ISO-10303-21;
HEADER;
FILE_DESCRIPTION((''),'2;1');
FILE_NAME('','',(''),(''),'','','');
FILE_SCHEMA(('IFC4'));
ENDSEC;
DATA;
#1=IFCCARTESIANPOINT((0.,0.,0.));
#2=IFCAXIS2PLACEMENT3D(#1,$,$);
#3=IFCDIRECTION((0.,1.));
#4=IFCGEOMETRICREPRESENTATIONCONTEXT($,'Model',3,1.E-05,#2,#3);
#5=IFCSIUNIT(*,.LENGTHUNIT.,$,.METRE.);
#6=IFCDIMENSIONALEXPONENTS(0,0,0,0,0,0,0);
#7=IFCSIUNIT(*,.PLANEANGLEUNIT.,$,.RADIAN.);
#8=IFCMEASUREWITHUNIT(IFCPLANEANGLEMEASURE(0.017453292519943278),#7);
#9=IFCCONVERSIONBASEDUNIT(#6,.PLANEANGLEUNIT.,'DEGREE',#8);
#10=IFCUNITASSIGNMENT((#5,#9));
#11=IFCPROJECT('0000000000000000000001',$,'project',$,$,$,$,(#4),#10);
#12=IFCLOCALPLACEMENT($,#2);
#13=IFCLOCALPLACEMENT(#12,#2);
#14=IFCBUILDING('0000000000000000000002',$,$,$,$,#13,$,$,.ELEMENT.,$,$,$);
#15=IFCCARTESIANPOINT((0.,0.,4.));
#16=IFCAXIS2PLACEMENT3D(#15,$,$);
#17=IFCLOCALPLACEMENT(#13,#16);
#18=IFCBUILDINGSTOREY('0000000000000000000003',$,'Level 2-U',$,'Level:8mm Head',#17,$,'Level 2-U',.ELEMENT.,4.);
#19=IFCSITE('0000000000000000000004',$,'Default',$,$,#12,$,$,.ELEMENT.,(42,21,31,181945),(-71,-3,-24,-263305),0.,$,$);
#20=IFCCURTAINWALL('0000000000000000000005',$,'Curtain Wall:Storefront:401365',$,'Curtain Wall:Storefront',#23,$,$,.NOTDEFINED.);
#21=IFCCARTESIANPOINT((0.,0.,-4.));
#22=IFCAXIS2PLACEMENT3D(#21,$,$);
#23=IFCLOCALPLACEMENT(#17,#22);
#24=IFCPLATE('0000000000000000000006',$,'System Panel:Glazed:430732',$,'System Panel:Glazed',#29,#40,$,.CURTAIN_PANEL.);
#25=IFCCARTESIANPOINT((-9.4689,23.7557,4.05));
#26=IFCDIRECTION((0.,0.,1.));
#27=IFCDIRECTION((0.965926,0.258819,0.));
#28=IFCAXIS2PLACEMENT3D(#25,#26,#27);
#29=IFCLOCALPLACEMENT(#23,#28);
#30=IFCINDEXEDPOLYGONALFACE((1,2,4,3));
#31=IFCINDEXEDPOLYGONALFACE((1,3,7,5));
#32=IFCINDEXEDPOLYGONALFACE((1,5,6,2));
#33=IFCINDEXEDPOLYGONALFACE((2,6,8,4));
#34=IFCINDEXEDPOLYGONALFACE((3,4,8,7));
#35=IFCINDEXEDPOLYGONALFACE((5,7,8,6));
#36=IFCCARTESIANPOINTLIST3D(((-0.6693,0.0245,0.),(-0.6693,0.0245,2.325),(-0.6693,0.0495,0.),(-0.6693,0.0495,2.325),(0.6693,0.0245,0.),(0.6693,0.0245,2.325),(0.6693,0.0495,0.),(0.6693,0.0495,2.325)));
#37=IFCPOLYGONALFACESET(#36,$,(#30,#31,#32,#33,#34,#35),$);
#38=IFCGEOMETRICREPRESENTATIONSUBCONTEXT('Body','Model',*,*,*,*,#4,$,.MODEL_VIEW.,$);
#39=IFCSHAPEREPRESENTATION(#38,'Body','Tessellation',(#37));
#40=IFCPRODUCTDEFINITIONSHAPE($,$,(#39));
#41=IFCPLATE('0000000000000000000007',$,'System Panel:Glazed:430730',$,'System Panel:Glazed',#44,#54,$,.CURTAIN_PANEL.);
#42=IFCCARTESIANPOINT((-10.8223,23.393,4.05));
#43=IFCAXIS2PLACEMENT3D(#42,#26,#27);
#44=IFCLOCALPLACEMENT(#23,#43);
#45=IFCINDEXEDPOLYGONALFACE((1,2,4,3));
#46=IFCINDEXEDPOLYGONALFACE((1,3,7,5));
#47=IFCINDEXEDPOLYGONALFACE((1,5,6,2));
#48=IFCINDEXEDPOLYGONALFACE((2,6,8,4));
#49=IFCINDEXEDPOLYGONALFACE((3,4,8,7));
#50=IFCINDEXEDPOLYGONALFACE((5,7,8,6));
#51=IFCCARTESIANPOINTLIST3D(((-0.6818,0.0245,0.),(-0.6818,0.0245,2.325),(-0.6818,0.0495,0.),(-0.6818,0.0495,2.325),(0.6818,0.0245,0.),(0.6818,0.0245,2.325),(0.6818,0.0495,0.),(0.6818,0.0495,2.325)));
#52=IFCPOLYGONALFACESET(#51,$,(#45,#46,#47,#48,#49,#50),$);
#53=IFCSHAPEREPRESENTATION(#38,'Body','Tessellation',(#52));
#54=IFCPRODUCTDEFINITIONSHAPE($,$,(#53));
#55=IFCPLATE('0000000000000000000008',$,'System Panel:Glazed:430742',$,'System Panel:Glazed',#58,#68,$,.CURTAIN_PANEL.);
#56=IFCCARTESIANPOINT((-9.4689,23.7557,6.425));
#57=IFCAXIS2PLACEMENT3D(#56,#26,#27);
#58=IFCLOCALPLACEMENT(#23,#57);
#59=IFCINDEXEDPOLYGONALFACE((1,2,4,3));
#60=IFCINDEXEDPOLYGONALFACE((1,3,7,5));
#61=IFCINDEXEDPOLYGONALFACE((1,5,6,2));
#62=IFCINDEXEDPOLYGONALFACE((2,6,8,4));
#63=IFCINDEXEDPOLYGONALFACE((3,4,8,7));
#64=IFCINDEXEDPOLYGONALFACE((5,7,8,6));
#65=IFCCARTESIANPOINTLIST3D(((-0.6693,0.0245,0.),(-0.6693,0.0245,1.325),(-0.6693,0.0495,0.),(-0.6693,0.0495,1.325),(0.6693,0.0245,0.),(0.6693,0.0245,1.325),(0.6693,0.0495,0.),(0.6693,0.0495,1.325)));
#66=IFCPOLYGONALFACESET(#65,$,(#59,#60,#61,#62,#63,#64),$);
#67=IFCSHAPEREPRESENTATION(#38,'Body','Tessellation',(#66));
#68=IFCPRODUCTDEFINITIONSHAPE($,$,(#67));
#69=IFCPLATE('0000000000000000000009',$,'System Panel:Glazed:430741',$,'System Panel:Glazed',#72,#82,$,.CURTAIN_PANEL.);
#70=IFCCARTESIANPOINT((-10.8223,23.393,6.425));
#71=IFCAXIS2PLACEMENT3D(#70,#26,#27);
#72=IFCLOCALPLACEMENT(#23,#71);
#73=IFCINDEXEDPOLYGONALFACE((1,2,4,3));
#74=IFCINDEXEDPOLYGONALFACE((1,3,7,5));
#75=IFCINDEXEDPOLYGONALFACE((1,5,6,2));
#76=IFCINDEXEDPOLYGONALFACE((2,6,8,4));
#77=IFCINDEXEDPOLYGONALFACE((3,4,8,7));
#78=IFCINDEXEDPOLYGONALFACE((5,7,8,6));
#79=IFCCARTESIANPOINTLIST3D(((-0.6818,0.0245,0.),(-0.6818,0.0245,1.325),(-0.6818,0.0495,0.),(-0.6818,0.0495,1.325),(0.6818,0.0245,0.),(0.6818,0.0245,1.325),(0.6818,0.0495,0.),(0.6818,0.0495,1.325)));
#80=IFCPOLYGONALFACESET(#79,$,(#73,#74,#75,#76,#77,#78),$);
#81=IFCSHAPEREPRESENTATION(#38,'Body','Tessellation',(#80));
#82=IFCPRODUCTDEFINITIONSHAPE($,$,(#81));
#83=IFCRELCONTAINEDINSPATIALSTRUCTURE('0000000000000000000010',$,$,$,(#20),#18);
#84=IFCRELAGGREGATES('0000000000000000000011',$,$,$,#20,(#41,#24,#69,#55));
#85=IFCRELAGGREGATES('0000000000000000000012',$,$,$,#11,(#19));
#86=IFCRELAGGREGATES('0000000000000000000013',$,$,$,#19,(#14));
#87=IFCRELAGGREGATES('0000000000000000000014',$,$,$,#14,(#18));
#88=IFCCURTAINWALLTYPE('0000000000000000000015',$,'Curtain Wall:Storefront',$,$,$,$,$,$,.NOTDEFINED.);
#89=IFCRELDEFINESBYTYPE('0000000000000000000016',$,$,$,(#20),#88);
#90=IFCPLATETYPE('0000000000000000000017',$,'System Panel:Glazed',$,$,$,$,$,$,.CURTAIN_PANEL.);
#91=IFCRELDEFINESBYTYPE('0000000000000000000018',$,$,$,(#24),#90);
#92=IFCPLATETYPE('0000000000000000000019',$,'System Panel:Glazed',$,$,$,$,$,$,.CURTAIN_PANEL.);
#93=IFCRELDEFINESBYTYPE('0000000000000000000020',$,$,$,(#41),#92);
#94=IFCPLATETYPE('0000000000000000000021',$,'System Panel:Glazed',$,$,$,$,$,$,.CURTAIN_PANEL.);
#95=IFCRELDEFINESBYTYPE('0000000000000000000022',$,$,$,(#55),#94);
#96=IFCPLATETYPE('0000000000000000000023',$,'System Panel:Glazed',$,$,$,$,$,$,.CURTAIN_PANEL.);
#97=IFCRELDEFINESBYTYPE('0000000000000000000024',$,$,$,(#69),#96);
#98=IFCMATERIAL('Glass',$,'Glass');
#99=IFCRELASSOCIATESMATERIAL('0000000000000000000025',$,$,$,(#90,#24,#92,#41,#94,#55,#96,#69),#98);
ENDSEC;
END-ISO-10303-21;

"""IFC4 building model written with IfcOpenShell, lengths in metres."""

from ifc_helpers import new_model, entity, si_unit, converted_unit, direction, frame, origin, place, context, subcontext, project, spatial, indexed_curve, outline, extrude, source, transform, mapped, material, type_object, type_shapes, element, aggregate, save


model = new_model("IFC4")

# Units and contexts
model_context = context("Model", 3, precision=1e-05, world=origin(), true_north=direction((0.0, 1.0)))
body_context = subcontext(model_context, "Body", "Model", "MODEL_VIEW")
ifc_project = project(units=[si_unit("LENGTHUNIT", "METRE"), converted_unit("PLANEANGLEUNIT", "DEGREE", entity("IfcPlaneAngleMeasure", 0.017453292519943278), si_unit("PLANEANGLEUNIT", "RADIAN"), dimensions=[0, 0, 0, 0, 0, 0, 0])], contexts=[model_context])

# Site, building, storey
site_placement = place(None, origin())
site = spatial("IfcSite", under=ifc_project, at=site_placement, Name="Default", CompositionType="ELEMENT", RefLatitude=(42, 21, 31, 181945), RefLongitude=(-71, -3, -24, -263305), RefElevation=0.0)
building_placement = place(site_placement, origin())
building = spatial("IfcBuilding", under=site, at=building_placement, CompositionType="ELEMENT")
storey_placement = place(building_placement, frame((0.0, 0.0, 4.0)))
storey = spatial("IfcBuildingStorey", under=building, at=storey_placement, Name="Level 2-U", ObjectType="Level:8mm Head", LongName="Level 2-U", CompositionType="ELEMENT", Elevation=4.0)

# Curtain wall, plates
curtain_wall_type = type_object("IfcCurtainWallType", Name="Curtain Wall:Storefront", PredefinedType="NOTDEFINED")
curtain_wall_placement = place(storey_placement, frame((0.0, 0.0, -4.0)))
curtain_wall = element("IfcCurtainWall", 1, at=curtain_wall_placement, inside=storey, type_object=curtain_wall_type, Name="Curtain Wall:Storefront:401365", ObjectType="Curtain Wall:Storefront", PredefinedType="NOTDEFINED")
ifc_material_1 = material(Name="Glass", Category="Glass")
plate_type_1 = type_object("IfcPlateType", Name="System Panel:Glazed", PredefinedType="CURTAIN_PANEL", material=ifc_material_1)
shared_shape_1 = source(origin(), body_context, "Body", "SweptSolid", [
    extrude(outline(indexed_curve([(-0.0125, -0.6693), (0.0125, -0.6693), (0.0125, 0.6693), (-0.0125, 0.6693), (-0.0125, -0.6693)], self_intersect=False)), frame((0.0, 0.037, 0.0), z_axis=(0.0, 0.0, 1.0), x_axis=(0.0, 1.0, 0.0)), (0.0, 0.0, 1.0), 2.325),
])
type_shapes(plate_type_1, [shared_shape_1])
plate_1_placement = place(curtain_wall_placement, frame((-9.4689, 23.7557, 4.05), z_axis=(0.0, 0.0, 1.0), x_axis=(0.965926, 0.258819, 0.0)))
plate_1 = element("IfcPlate", 2, at=plate_1_placement, type_object=plate_type_1, material=ifc_material_1, Name="System Panel:Glazed:430732", ObjectType="System Panel:Glazed", PredefinedType="CURTAIN_PANEL", context=body_context, shape_type="MappedRepresentation", body=[
    mapped(shared_shape_1, transform((0.0, 0.0, 0.0), scale=1.0)),
])
plate_type_2 = type_object("IfcPlateType", Name="System Panel:Glazed", PredefinedType="CURTAIN_PANEL", material=ifc_material_1)
shared_shape_2 = source(origin(), body_context, "Body", "SweptSolid", [
    extrude(outline(indexed_curve([(-0.0125, -0.6818), (0.0125, -0.6818), (0.0125, 0.6818), (-0.0125, 0.6818), (-0.0125, -0.6818)], self_intersect=False)), frame((0.0, 0.037, 0.0), z_axis=(0.0, 0.0, 1.0), x_axis=(0.0, 1.0, 0.0)), (0.0, 0.0, 1.0), 2.325),
])
type_shapes(plate_type_2, [shared_shape_2])
plate_2_placement = place(curtain_wall_placement, frame((-10.8223, 23.393, 4.05), z_axis=(0.0, 0.0, 1.0), x_axis=(0.965926, 0.258819, 0.0)))
plate_2 = element("IfcPlate", 3, at=plate_2_placement, type_object=plate_type_2, material=ifc_material_1, Name="System Panel:Glazed:430730", ObjectType="System Panel:Glazed", PredefinedType="CURTAIN_PANEL", context=body_context, shape_type="MappedRepresentation", body=[
    mapped(shared_shape_2, transform((0.0, 0.0, 0.0), scale=1.0)),
])
plate_type_3 = type_object("IfcPlateType", Name="System Panel:Glazed", PredefinedType="CURTAIN_PANEL", material=ifc_material_1)
shared_shape_3 = source(origin(), body_context, "Body", "SweptSolid", [
    extrude(outline(indexed_curve([(-0.0125, -0.6693), (0.0125, -0.6693), (0.0125, 0.6693), (-0.0125, 0.6693), (-0.0125, -0.6693)], self_intersect=False)), frame((0.0, 0.037, 0.0), z_axis=(0.0, 0.0, 1.0), x_axis=(0.0, 1.0, 0.0)), (0.0, 0.0, 1.0), 1.325),
])
type_shapes(plate_type_3, [shared_shape_3])
plate_3_placement = place(curtain_wall_placement, frame((-9.4689, 23.7557, 6.425), z_axis=(0.0, 0.0, 1.0), x_axis=(0.965926, 0.258819, 0.0)))
plate_3 = element("IfcPlate", 4, at=plate_3_placement, type_object=plate_type_3, material=ifc_material_1, Name="System Panel:Glazed:430742", ObjectType="System Panel:Glazed", PredefinedType="CURTAIN_PANEL", context=body_context, shape_type="MappedRepresentation", body=[
    mapped(shared_shape_3, transform((0.0, 0.0, 0.0), scale=1.0)),
])
plate_type_4 = type_object("IfcPlateType", Name="System Panel:Glazed", PredefinedType="CURTAIN_PANEL", material=ifc_material_1)
shared_shape_4 = source(origin(), body_context, "Body", "SweptSolid", [
    extrude(outline(indexed_curve([(-0.0125, -0.6818), (0.0125, -0.6818), (0.0125, 0.6818), (-0.0125, 0.6818), (-0.0125, -0.6818)], self_intersect=False)), frame((0.0, 0.037, 0.0), z_axis=(0.0, 0.0, 1.0), x_axis=(0.0, 1.0, 0.0)), (0.0, 0.0, 1.0), 1.325),
])
type_shapes(plate_type_4, [shared_shape_4])
plate_4_placement = place(curtain_wall_placement, frame((-10.8223, 23.393, 6.425), z_axis=(0.0, 0.0, 1.0), x_axis=(0.965926, 0.258819, 0.0)))
plate_4 = element("IfcPlate", 5, at=plate_4_placement, type_object=plate_type_4, material=ifc_material_1, Name="System Panel:Glazed:430741", ObjectType="System Panel:Glazed", PredefinedType="CURTAIN_PANEL", context=body_context, shape_type="MappedRepresentation", body=[
    mapped(shared_shape_4, transform((0.0, 0.0, 0.0), scale=1.0)),
])
aggregate(curtain_wall, [plate_2, plate_1, plate_4, plate_3])

save(model, "model.ifc")
